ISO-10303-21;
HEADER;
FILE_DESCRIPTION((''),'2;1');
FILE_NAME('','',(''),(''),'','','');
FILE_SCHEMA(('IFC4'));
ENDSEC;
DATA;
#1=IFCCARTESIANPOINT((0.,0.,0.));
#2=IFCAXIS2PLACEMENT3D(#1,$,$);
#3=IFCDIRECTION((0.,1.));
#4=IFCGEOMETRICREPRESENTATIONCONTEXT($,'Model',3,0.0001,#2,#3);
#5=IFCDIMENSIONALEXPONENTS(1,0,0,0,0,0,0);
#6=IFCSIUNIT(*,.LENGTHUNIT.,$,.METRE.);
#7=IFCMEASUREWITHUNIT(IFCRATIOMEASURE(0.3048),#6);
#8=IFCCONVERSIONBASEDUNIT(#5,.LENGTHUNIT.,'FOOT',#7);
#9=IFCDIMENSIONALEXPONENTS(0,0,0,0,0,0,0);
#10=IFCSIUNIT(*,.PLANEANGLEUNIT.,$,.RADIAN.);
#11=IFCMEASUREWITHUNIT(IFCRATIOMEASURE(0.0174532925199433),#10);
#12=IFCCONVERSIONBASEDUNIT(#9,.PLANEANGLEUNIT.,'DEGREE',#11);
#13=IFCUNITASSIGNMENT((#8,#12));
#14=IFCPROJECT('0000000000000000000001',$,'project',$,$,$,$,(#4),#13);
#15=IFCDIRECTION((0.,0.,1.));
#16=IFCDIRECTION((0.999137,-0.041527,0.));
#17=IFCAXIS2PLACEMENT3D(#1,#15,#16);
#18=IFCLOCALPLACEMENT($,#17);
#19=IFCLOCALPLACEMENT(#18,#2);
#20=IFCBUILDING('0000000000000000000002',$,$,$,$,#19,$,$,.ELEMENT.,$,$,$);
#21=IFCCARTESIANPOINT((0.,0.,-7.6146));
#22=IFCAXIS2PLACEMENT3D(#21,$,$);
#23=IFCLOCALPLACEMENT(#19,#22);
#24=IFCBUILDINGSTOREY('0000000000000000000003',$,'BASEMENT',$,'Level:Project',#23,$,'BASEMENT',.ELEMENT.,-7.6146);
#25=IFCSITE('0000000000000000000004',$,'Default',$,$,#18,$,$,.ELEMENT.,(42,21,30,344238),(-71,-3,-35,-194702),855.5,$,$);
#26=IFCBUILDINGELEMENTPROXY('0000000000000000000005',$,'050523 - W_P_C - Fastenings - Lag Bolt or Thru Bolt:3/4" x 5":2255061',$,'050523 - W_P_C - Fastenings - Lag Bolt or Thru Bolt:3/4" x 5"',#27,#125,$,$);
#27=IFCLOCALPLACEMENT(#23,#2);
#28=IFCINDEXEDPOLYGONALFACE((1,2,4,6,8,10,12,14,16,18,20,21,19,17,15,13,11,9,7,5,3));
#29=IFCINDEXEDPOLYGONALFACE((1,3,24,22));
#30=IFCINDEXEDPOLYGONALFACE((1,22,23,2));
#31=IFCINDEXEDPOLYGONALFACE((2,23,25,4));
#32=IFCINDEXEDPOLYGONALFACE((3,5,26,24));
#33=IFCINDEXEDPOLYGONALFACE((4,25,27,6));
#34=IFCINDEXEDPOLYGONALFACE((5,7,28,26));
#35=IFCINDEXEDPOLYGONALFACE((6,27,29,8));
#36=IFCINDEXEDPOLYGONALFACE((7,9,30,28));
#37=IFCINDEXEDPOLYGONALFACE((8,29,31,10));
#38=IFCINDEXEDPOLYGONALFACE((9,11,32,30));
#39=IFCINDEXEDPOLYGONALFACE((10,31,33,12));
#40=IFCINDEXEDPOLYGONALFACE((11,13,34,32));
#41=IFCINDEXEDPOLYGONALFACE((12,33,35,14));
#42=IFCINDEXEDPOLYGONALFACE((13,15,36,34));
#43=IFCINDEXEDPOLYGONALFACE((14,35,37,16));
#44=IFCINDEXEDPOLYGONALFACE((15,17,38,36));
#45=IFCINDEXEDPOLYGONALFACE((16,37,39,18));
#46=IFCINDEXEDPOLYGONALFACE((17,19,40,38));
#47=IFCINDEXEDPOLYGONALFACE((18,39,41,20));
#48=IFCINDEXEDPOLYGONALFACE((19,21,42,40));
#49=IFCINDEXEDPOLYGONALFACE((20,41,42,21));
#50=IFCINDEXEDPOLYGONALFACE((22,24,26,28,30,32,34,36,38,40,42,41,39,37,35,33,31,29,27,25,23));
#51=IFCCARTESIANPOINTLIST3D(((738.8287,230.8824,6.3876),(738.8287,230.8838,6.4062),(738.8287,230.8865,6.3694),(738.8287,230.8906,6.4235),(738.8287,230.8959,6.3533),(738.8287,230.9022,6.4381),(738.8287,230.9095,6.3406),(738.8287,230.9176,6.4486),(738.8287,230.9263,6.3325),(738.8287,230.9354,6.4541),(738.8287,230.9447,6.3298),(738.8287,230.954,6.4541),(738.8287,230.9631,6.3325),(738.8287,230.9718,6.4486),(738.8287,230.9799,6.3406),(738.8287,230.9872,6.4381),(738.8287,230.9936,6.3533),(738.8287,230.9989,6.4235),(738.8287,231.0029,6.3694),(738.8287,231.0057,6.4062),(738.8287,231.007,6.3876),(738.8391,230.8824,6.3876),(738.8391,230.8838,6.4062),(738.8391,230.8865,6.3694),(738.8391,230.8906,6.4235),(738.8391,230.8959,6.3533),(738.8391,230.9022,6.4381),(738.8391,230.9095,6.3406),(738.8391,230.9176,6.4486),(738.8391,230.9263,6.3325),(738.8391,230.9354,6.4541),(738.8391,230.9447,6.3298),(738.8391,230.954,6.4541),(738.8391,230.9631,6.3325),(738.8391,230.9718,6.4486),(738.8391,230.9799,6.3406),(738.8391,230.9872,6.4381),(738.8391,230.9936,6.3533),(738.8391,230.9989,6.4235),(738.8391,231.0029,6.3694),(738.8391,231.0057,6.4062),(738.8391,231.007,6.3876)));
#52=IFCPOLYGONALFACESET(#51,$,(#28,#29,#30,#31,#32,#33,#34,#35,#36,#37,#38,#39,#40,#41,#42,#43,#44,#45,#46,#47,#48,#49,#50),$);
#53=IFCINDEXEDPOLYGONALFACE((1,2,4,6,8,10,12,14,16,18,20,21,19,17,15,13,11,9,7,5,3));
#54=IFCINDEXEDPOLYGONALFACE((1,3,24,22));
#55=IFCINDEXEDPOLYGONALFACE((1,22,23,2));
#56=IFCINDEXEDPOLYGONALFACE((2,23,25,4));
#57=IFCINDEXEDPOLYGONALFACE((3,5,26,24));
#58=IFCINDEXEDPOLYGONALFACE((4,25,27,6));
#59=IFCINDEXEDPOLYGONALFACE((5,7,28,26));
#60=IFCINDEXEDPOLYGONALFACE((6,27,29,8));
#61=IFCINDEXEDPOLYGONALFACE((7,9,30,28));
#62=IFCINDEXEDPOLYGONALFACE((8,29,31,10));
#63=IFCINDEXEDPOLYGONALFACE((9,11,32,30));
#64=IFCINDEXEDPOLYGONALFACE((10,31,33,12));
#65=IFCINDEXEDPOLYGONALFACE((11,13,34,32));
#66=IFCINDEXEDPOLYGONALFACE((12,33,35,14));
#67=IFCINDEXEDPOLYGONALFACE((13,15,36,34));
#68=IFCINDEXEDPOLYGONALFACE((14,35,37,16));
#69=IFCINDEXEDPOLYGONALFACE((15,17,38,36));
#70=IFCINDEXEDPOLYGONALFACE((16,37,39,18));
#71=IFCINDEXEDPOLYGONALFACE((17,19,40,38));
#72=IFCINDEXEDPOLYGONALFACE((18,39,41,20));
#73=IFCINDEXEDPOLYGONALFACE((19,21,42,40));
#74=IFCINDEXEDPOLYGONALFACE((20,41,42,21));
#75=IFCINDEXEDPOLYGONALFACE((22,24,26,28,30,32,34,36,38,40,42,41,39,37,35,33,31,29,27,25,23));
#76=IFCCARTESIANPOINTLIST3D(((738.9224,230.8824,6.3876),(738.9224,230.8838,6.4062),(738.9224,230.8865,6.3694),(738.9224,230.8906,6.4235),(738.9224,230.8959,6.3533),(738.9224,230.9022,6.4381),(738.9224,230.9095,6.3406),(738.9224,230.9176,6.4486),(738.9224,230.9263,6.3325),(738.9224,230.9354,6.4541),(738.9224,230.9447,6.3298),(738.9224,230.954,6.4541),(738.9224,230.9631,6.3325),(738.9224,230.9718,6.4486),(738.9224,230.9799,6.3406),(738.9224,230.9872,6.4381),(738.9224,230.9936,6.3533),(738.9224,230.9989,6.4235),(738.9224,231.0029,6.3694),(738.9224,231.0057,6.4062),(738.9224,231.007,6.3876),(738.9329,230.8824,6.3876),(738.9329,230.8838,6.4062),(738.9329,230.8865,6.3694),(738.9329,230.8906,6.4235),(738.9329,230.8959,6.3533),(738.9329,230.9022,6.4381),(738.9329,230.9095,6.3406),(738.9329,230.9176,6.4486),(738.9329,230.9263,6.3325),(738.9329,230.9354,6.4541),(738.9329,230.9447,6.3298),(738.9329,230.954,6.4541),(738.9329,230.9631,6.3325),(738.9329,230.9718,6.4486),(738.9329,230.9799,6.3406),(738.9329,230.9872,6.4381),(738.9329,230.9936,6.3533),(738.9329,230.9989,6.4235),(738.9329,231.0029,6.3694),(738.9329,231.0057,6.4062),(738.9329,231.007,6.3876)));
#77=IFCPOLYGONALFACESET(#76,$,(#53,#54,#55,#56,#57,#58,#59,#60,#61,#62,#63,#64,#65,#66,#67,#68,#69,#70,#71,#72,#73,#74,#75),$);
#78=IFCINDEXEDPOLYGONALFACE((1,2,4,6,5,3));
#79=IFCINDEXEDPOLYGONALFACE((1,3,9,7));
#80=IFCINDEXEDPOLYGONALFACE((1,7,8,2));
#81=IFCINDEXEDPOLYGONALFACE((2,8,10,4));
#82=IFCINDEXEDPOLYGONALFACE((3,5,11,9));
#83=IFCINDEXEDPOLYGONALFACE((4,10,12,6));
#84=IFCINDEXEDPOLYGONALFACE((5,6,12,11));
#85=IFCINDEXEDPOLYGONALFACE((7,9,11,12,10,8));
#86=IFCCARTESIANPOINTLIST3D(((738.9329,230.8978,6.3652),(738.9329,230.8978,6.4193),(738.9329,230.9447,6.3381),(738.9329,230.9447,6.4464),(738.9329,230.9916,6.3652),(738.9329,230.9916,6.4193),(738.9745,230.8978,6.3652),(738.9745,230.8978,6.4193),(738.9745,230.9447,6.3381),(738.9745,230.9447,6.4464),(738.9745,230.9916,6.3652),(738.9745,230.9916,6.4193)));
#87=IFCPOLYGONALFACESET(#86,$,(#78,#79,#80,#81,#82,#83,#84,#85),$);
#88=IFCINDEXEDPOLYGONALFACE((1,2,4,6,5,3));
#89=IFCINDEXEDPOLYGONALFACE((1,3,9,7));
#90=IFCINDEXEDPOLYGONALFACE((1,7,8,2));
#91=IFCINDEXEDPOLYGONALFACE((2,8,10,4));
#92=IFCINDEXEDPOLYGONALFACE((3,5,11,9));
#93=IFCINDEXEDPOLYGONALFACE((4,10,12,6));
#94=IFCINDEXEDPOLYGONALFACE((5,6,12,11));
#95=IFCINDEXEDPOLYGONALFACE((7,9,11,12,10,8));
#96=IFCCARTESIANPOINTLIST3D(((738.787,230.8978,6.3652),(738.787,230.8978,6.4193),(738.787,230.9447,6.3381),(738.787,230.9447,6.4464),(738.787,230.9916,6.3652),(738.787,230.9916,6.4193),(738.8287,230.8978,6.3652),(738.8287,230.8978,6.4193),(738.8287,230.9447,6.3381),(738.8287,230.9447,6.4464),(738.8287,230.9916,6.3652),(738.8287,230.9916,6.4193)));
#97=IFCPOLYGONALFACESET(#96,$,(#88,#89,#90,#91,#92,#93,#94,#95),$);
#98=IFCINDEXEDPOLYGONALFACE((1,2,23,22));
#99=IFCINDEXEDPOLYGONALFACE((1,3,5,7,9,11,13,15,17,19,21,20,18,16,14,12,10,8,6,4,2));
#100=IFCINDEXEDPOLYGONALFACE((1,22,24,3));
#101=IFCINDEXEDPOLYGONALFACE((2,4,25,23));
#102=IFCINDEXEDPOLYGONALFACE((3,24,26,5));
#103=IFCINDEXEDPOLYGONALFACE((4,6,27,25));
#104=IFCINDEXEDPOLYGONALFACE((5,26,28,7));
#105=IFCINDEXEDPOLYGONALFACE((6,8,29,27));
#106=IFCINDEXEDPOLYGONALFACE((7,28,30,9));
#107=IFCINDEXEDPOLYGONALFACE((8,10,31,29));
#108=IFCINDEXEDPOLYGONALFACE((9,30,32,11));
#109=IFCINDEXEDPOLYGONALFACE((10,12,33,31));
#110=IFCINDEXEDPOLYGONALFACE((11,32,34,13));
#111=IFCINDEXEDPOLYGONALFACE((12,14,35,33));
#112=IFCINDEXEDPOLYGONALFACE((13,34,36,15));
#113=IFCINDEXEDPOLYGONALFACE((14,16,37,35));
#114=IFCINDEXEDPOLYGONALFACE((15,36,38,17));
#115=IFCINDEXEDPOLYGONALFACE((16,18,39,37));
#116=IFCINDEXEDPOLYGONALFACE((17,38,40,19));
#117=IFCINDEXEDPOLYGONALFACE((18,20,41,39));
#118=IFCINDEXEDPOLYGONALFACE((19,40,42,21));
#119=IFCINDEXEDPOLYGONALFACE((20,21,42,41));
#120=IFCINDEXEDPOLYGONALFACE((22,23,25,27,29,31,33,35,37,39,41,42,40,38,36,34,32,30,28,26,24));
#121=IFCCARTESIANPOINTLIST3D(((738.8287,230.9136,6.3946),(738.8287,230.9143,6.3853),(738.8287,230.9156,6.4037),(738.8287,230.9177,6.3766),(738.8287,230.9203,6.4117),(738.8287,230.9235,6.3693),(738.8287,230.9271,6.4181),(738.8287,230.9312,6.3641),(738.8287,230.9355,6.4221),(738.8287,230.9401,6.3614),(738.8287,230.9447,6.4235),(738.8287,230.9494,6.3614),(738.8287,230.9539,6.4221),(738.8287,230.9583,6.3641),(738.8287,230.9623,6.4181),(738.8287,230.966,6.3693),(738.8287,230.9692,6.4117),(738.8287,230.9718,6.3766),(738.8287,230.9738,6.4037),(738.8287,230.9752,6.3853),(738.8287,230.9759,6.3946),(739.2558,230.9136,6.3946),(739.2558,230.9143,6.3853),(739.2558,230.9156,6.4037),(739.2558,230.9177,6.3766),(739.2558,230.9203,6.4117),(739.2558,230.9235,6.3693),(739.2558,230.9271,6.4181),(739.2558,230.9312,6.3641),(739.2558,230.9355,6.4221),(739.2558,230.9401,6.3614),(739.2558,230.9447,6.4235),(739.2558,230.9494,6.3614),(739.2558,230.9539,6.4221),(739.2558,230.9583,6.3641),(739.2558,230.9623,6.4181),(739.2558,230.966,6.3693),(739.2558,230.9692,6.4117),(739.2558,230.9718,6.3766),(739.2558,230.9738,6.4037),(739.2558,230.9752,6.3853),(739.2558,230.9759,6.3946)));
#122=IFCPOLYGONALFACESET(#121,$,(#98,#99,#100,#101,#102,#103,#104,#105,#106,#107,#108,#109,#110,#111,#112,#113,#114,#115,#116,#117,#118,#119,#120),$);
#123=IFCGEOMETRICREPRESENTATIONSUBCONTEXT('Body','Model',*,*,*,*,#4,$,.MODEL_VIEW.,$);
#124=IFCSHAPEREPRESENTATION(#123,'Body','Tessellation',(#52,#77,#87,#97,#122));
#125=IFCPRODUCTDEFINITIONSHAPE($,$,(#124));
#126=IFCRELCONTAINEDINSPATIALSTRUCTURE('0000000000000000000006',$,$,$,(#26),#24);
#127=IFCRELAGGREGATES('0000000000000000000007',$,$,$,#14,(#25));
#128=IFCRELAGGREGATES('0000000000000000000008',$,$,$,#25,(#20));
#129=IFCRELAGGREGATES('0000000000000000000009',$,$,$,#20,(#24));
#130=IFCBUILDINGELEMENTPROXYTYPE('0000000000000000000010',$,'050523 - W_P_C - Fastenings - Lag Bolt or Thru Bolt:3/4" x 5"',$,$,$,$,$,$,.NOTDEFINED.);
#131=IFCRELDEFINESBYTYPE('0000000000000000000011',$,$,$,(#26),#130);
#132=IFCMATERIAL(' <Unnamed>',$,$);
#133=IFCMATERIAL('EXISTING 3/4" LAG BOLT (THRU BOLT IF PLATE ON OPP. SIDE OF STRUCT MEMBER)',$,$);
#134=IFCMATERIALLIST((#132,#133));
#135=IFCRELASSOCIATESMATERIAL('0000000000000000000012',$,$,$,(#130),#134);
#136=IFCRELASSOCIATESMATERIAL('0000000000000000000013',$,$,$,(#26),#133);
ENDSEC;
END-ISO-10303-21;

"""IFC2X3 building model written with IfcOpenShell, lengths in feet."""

from ifc_helpers import new_model, entity, si_unit, converted_unit, direction, frame, frame_2d, origin, place, context, subcontext, project, spatial, polyline, circle, outline, extrude, source, transform, mapped, material, material_list, type_object, type_shapes, element, save


model = new_model("IFC2X3")

# Units and contexts
model_context = context("Model", 3, precision=0.0001, world=origin(), true_north=direction((0.0, 1.0)))
body_context = subcontext(model_context, "Body", "Model", "MODEL_VIEW")
ifc_project = project(units=[converted_unit("LENGTHUNIT", "FOOT", entity("IfcRatioMeasure", 0.3048), si_unit("LENGTHUNIT", "METRE"), dimensions=[1, 0, 0, 0, 0, 0, 0]), converted_unit("PLANEANGLEUNIT", "DEGREE", entity("IfcRatioMeasure", 0.0174532925199433), si_unit("PLANEANGLEUNIT", "RADIAN"), dimensions=[0, 0, 0, 0, 0, 0, 0])], contexts=[model_context])

# Site, building, storey
site_placement = place(None, frame((0.0, 0.0, 0.0), z_axis=(0.0, 0.0, 1.0), x_axis=(0.999137, -0.041527, 0.0)))
site = spatial("IfcSite", under=ifc_project, at=site_placement, Name="Default", CompositionType="ELEMENT", RefLatitude=(42, 21, 30, 344238), RefLongitude=(-71, -3, -35, -194702), RefElevation=855.5)
building_placement = place(site_placement, origin())
building = spatial("IfcBuilding", under=site, at=building_placement, CompositionType="ELEMENT")
storey_placement = place(building_placement, frame((0.0, 0.0, -7.6146)))
storey = spatial("IfcBuildingStorey", under=building, at=storey_placement, Name="BASEMENT", ObjectType="Level:Project", LongName="BASEMENT", CompositionType="ELEMENT", Elevation=-7.6146)

# Building element proxy
ifc_material_1 = material(Name="EXISTING 3/4\" LAG BOLT (THRU BOLT IF PLATE ON OPP. SIDE OF STRUCT MEMBER)")
ifc_material_2 = material(Name=" <Unnamed>")
ifc_material_list_1 = material_list([ifc_material_2, ifc_material_1])
building_element_proxy_type_1 = type_object("IfcBuildingElementProxyType", Name="050523 - W_P_C - Fastenings - Lag Bolt or Thru Bolt:3/4\" x 5\"", PredefinedType="NOTDEFINED", material=ifc_material_list_1)
shared_shape_1 = source(origin(), body_context, "Body", "SweptSolid", [
    extrude(circle(Radius=0.0625, at=frame_2d((0.0, 0.0), x_axis=(1.0, 0.0))), frame((0.0, 0.0, 0.0), z_axis=(0.0, 0.0, 1.0), x_axis=(0.0, -1.0, 0.0)), (0.0, 0.0, 1.0), 0.0104),
    extrude(circle(Radius=0.0625, at=frame_2d((0.0, 0.0), x_axis=(1.0, 0.0))), frame((0.0, 0.0, -0.0938), z_axis=(0.0, 0.0, 1.0), x_axis=(0.0, -1.0, 0.0)), (0.0, 0.0, 1.0), 0.0104),
    extrude(outline(polyline([(-0.0271, -0.0469), (0.0271, -0.0469), (0.0541, 0.0), (0.0271, 0.0469), (-0.0271, 0.0469), (-0.0541, 0.0), (-0.0271, -0.0469)])), frame((0.0, 0.0, -0.1354), z_axis=(0.0, 0.0, 1.0), x_axis=(0.866025, -0.5, 0.0)), (0.0, 0.0, 1.0), 0.0417),
    extrude(outline(polyline([(-0.0271, -0.0469), (0.0271, -0.0469), (0.0541, 0.0), (0.0271, 0.0469), (-0.0271, 0.0469), (-0.0541, 0.0), (-0.0271, -0.0469)])), frame((0.0, 0.0, 0.0104), z_axis=(0.0, 0.0, 1.0), x_axis=(0.0, -1.0, 0.0)), (0.0, 0.0, 1.0), 0.0417),
    extrude(circle(Radius=0.0312, at=frame_2d((0.0, 0.0), x_axis=(1.0, 0.0))), frame((0.0, 0.0, -0.4167), z_axis=(0.0, 0.0, 1.0), x_axis=(0.0, 1.0, 0.0)), (0.0, 0.0, 1.0), 0.4271),
])
type_shapes(building_element_proxy_type_1, [shared_shape_1])
for number, where, z_axis, x_axis, name in (
    (1, (738.8391, 230.9447, 6.3923), (-1.0, 0.0, 0.0), (0.0, -1.0, 0.0), "050523 - W_P_C - Fastenings - Lag Bolt or Thru Bolt:3/4\" x 5\":2255061"),
):
    element("IfcBuildingElementProxy", number, at=place(storey_placement, frame(where, z_axis=z_axis, x_axis=x_axis)), inside=storey, type_object=building_element_proxy_type_1, material=ifc_material_1, Name=name, ObjectType="050523 - W_P_C - Fastenings - Lag Bolt or Thru Bolt:3/4\" x 5\"", context=body_context, shape_type="MappedRepresentation", body=[
        mapped(shared_shape_1, transform((0.0, 0.0, 0.0), scale=1.0)),
    ])

save(model, "model.ifc")
